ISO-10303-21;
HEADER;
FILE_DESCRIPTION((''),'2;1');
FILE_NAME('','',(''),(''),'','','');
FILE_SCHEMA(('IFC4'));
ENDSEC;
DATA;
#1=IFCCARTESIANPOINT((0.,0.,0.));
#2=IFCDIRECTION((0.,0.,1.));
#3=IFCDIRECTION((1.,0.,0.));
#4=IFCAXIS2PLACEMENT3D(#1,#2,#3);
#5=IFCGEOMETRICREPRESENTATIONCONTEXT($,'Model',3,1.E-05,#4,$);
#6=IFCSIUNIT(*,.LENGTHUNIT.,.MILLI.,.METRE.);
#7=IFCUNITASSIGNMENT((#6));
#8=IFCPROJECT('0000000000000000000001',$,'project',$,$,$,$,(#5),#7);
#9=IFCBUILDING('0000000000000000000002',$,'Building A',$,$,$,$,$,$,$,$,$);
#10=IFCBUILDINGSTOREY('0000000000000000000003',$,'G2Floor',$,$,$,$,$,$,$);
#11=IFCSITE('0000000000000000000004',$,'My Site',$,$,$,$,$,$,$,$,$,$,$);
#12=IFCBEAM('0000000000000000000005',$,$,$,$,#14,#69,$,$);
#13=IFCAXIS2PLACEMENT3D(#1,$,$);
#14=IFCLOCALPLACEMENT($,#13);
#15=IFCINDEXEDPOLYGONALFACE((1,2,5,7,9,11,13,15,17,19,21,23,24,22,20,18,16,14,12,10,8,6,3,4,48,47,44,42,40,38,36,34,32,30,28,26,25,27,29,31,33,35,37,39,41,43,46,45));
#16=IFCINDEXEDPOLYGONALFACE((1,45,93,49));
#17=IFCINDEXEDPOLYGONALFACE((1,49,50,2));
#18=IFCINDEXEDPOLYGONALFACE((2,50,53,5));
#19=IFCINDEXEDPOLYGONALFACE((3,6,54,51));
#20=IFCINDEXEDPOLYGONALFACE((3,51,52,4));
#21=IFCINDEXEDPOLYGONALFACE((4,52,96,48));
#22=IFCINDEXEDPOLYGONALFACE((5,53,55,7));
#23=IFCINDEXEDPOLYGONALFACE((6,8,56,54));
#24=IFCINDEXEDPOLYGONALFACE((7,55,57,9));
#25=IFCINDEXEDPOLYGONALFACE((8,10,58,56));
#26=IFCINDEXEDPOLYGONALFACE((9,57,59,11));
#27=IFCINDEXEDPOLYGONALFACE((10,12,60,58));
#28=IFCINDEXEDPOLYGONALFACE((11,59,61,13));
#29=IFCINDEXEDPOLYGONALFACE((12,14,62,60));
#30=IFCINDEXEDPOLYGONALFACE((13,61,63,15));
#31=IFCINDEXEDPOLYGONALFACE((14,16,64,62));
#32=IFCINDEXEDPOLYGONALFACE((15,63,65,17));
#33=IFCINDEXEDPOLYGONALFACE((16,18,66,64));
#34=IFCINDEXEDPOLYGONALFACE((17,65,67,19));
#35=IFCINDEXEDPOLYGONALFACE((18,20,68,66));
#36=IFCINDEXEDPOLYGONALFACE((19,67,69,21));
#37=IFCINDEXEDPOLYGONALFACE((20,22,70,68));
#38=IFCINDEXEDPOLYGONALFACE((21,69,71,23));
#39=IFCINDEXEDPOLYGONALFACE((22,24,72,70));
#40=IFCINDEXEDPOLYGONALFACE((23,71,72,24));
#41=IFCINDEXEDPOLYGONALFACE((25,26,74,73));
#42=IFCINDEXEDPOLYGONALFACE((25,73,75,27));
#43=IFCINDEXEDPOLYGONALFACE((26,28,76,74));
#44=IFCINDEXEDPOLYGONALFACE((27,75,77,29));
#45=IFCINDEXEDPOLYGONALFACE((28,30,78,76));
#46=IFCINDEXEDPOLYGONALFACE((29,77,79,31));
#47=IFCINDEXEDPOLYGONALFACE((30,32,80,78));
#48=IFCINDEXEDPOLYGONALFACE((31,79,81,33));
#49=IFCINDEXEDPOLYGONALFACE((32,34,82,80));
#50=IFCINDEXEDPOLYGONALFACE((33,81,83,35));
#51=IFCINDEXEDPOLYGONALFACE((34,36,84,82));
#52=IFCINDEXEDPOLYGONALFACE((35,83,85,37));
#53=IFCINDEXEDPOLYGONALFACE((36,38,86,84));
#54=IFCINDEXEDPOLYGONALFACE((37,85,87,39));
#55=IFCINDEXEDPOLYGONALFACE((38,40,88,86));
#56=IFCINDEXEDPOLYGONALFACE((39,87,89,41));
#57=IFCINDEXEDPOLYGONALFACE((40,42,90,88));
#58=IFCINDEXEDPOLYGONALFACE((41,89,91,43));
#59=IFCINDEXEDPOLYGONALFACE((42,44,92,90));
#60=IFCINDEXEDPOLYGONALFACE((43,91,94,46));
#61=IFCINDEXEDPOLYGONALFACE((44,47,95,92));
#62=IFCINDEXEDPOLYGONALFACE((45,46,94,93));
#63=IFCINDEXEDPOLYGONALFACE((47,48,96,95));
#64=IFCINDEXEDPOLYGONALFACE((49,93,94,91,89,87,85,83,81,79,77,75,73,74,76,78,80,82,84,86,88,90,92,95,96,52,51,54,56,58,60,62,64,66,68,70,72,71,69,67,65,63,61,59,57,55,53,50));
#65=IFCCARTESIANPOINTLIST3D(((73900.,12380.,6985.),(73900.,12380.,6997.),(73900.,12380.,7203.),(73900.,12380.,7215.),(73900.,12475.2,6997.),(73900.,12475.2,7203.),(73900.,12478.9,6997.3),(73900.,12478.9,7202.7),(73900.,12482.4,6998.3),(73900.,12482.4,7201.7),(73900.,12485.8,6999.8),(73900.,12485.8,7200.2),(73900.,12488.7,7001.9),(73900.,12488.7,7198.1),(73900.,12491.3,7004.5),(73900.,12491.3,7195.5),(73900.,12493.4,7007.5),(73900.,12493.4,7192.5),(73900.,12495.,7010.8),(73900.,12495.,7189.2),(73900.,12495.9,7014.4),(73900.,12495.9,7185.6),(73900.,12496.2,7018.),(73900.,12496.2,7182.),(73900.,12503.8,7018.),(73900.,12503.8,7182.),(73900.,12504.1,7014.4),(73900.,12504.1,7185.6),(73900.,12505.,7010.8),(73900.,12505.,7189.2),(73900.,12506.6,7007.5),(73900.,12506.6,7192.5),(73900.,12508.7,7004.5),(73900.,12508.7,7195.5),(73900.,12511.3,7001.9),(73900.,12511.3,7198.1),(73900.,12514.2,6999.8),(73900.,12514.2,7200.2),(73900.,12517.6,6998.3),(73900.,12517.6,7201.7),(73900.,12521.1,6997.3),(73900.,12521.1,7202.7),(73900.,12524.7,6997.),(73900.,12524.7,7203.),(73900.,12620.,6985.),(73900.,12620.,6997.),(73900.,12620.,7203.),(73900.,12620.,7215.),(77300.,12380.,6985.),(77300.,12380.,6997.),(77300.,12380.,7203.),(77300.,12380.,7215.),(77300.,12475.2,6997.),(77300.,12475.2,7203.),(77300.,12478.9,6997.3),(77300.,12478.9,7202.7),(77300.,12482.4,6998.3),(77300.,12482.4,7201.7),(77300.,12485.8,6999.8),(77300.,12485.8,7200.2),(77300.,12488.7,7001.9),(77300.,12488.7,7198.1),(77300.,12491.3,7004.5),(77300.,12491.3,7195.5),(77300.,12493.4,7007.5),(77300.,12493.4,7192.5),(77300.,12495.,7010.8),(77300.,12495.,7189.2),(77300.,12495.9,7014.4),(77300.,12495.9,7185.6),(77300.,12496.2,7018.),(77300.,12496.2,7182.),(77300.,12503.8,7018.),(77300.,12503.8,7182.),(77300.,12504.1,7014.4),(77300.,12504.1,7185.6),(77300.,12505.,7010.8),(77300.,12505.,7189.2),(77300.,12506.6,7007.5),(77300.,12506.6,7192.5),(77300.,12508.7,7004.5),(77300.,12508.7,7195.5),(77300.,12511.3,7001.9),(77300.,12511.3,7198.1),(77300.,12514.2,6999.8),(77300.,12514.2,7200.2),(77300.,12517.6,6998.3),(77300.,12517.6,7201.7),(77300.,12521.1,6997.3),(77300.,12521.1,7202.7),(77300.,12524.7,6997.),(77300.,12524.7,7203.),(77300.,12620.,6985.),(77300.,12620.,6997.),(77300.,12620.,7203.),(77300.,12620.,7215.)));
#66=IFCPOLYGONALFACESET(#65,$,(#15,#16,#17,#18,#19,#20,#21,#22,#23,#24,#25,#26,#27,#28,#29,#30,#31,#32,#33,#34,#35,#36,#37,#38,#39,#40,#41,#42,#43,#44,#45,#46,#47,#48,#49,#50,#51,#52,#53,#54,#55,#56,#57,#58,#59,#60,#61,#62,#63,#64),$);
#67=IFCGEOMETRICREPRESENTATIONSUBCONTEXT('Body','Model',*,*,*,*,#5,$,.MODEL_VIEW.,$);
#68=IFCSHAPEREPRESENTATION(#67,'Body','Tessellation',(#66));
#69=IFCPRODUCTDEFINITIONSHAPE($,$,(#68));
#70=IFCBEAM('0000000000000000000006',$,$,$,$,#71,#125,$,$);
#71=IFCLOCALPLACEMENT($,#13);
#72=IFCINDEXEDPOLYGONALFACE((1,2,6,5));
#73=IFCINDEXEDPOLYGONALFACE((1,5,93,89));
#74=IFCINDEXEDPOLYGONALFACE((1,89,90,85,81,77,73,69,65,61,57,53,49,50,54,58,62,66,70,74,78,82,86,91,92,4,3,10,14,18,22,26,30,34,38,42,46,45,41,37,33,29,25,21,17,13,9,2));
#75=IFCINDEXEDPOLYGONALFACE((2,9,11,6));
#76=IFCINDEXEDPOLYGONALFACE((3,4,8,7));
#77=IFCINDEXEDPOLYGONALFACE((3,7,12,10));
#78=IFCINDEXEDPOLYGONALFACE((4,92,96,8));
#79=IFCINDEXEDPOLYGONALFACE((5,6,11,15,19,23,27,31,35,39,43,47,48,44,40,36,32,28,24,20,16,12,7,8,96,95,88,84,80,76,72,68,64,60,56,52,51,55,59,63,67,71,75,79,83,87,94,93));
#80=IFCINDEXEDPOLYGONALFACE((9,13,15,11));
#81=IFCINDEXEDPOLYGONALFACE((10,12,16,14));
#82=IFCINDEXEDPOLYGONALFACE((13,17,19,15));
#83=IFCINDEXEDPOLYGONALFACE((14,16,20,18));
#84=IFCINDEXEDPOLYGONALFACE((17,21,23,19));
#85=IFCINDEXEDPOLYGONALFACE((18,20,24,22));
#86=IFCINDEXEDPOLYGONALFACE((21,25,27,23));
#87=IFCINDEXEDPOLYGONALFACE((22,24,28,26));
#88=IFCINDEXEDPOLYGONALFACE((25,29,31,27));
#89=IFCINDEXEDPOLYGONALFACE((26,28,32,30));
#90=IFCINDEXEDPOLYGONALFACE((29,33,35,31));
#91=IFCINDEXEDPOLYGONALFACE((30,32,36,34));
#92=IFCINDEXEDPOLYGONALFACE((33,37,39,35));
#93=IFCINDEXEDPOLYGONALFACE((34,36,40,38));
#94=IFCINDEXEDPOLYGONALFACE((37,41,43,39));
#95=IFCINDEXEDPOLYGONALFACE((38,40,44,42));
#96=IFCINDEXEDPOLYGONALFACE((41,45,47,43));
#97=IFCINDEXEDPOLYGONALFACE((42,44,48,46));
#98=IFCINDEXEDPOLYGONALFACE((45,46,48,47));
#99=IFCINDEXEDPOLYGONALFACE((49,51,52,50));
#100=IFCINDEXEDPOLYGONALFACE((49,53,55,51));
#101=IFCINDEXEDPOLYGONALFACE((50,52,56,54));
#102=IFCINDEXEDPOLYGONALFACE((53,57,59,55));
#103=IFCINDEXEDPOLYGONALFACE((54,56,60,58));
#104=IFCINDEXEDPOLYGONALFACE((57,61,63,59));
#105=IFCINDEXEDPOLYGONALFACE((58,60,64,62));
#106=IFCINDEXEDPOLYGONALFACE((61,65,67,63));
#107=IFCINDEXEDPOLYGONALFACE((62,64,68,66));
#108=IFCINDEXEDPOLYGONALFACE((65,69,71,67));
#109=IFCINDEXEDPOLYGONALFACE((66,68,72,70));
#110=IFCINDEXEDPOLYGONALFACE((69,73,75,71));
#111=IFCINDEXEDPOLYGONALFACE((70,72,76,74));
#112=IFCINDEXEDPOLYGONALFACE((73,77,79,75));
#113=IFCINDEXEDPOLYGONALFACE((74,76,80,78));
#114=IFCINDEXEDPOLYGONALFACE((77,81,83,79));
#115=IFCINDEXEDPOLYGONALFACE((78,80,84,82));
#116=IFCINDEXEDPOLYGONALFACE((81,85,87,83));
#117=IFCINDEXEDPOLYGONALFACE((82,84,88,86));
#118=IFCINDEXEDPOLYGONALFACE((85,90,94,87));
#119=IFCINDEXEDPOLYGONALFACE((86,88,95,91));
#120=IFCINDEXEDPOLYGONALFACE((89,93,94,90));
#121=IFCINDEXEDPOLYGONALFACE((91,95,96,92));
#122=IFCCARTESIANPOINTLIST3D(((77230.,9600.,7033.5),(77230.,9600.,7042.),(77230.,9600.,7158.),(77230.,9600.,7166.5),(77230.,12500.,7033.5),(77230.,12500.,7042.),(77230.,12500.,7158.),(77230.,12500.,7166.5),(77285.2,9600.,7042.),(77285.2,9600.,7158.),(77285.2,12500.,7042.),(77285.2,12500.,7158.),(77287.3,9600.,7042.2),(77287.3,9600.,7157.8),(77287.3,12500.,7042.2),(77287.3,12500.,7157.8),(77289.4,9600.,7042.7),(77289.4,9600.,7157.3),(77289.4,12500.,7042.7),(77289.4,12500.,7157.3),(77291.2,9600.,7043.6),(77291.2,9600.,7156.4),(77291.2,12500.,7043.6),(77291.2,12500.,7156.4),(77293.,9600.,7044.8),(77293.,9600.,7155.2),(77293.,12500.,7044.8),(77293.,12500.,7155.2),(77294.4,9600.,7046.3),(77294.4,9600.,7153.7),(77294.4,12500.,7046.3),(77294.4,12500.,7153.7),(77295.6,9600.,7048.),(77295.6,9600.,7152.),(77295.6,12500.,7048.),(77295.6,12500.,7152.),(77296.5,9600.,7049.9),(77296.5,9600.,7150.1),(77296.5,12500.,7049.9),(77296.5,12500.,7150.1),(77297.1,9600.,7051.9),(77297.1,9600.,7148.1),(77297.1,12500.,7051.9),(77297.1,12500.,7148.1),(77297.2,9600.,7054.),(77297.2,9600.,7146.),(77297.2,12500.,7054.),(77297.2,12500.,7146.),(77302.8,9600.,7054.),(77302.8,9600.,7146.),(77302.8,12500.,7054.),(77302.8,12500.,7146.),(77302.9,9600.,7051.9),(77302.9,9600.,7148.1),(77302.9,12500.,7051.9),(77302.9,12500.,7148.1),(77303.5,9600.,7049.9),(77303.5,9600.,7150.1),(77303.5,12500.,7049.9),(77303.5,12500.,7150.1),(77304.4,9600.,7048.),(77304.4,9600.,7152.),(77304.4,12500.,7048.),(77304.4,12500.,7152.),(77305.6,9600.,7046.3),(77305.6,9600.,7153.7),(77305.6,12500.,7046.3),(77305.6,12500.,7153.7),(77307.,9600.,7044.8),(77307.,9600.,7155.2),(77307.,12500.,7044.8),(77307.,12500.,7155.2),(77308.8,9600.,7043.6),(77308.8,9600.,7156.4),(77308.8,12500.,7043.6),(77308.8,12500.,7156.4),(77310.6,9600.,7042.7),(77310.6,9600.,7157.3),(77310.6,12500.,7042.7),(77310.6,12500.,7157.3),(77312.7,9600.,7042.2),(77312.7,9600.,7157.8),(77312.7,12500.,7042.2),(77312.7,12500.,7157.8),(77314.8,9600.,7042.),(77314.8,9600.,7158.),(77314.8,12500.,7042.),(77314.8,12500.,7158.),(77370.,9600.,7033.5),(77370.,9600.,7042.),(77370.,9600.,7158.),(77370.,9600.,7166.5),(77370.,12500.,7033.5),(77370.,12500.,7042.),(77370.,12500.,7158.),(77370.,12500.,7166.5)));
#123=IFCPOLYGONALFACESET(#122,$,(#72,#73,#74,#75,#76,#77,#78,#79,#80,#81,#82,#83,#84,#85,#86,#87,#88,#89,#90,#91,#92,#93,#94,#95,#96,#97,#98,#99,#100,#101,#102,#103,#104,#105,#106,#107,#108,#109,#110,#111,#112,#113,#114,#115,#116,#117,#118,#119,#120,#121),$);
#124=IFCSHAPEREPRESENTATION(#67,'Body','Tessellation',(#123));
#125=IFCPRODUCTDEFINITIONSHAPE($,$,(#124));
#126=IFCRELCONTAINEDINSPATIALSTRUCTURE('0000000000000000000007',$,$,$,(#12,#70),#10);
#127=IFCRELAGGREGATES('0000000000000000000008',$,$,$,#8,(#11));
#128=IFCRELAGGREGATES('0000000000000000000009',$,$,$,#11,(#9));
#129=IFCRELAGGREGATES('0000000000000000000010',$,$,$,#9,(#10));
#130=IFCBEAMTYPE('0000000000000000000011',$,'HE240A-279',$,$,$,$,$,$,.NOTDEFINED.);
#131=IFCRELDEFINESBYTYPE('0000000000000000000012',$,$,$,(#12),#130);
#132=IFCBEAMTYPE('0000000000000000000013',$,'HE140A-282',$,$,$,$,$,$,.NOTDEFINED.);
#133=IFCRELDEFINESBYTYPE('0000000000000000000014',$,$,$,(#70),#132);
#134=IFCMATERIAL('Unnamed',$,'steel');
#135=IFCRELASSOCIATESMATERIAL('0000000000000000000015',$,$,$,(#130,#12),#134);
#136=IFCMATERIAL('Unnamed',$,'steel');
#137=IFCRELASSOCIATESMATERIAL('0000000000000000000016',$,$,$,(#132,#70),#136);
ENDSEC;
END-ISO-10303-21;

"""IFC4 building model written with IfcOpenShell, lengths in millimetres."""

from ifc_helpers import new_model, si_unit, frame, origin_with_axes, place, context, subcontext, project, spatial, polyline, outline, extrude, material, material_profile, profile_set, profile_usage, type_object, element, save


model = new_model("IFC4")

# Units and contexts
model_context = context("Model", 3, precision=1e-05, world=origin_with_axes())
body_context = subcontext(model_context, "Body", "Model", "MODEL_VIEW")
ifc_project = project(units=[si_unit("LENGTHUNIT", "METRE", prefix="MILLI")], contexts=[model_context])

# Site, building, storey
site = spatial("IfcSite", under=ifc_project, Name="My Site")
building = spatial("IfcBuilding", under=site, Name="Building A")
storey = spatial("IfcBuildingStorey", under=building, Name="G2Floor")

# Beams
ifc_material_1 = material(Name="Unnamed", Category="steel")
ifc_material_profile_1 = material_profile(ifc_material_1, outline(polyline([(120.0, -115.0), (120.0, -103.0), (120.0, -103.0), (24.8, -103.0), (24.8, -103.0), (21.1, -102.7), (21.1, -102.7), (17.6, -101.7), (17.6, -101.7), (14.2, -100.2), (14.2, -100.2), (11.3, -98.1), (11.3, -98.1), (8.7, -95.5), (8.7, -95.5), (6.6, -92.5), (6.6, -92.5), (5.0, -89.2), (5.0, -89.2), (4.1, -85.6), (4.1, -85.6), (3.8, -82.0), (3.8, -82.0), (3.8, 82.0), (3.8, 82.0), (4.1, 85.6), (4.1, 85.6), (5.0, 89.2), (5.0, 89.2), (6.6, 92.5), (6.6, 92.5), (8.7, 95.5), (8.7, 95.5), (11.3, 98.1), (11.3, 98.1), (14.2, 100.2), (14.2, 100.2), (17.6, 101.7), (17.6, 101.7), (21.1, 102.7), (21.1, 102.7), (24.8, 103.0), (24.8, 103.0), (120.0, 103.0), (120.0, 103.0), (120.0, 115.0), (120.0, 115.0), (-120.0, 115.0), (-120.0, 115.0), (-120.0, 103.0), (-120.0, 103.0), (-24.8, 103.0), (-24.8, 103.0), (-21.1, 102.7), (-21.1, 102.7), (-17.6, 101.7), (-17.6, 101.7), (-14.2, 100.2), (-14.2, 100.2), (-11.3, 98.1), (-11.3, 98.1), (-8.7, 95.5), (-8.7, 95.5), (-6.6, 92.5), (-6.6, 92.5), (-5.0, 89.2), (-5.0, 89.2), (-4.1, 85.6), (-4.1, 85.6), (-3.8, 82.0), (-3.8, 82.0), (-3.8, -82.0), (-3.8, -82.0), (-4.1, -85.6), (-4.1, -85.6), (-5.0, -89.2), (-5.0, -89.2), (-6.6, -92.5), (-6.6, -92.5), (-8.7, -95.5), (-8.7, -95.5), (-11.3, -98.1), (-11.3, -98.1), (-14.2, -100.2), (-14.2, -100.2), (-17.6, -101.7), (-17.6, -101.7), (-21.1, -102.7), (-21.1, -102.7), (-24.8, -103.0), (-24.8, -103.0), (-120.0, -103.0), (-120.0, -103.0), (-120.0, -115.0), (-120.0, -115.0), (120.0, -115.0)])))
ifc_profile_set_1 = profile_set([ifc_material_profile_1], Name="HE240A-279")
ifc_profile_usage_1 = profile_usage(ifc_profile_set_1)
beam_type_1 = type_object("IfcBeamType", Name="HE240A-279", PredefinedType="NOTDEFINED", material=ifc_profile_set_1)
beam_1_placement = place(None, frame((73900.0, 12500.0, 7100.0), z_axis=(1.0, 0.0, 0.0), x_axis=(0.0, -1.0, 0.0)))
element("IfcBeam", 1, at=beam_1_placement, inside=storey, type_object=beam_type_1, material=ifc_profile_usage_1, context=body_context, shape_type="SweptSolid", body=[
    extrude(outline(polyline([(120.0, -115.0), (120.0, -103.0), (120.0, -103.0), (24.8, -103.0), (24.8, -103.0), (21.1, -102.7), (21.1, -102.7), (17.6, -101.7), (17.6, -101.7), (14.2, -100.2), (14.2, -100.2), (11.3, -98.1), (11.3, -98.1), (8.7, -95.5), (8.7, -95.5), (6.6, -92.5), (6.6, -92.5), (5.0, -89.2), (5.0, -89.2), (4.1, -85.6), (4.1, -85.6), (3.8, -82.0), (3.8, -82.0), (3.8, 82.0), (3.8, 82.0), (4.1, 85.6), (4.1, 85.6), (5.0, 89.2), (5.0, 89.2), (6.6, 92.5), (6.6, 92.5), (8.7, 95.5), (8.7, 95.5), (11.3, 98.1), (11.3, 98.1), (14.2, 100.2), (14.2, 100.2), (17.6, 101.7), (17.6, 101.7), (21.1, 102.7), (21.1, 102.7), (24.8, 103.0), (24.8, 103.0), (120.0, 103.0), (120.0, 103.0), (120.0, 115.0), (120.0, 115.0), (-120.0, 115.0), (-120.0, 115.0), (-120.0, 103.0), (-120.0, 103.0), (-24.8, 103.0), (-24.8, 103.0), (-21.1, 102.7), (-21.1, 102.7), (-17.6, 101.7), (-17.6, 101.7), (-14.2, 100.2), (-14.2, 100.2), (-11.3, 98.1), (-11.3, 98.1), (-8.7, 95.5), (-8.7, 95.5), (-6.6, 92.5), (-6.6, 92.5), (-5.0, 89.2), (-5.0, 89.2), (-4.1, 85.6), (-4.1, 85.6), (-3.8, 82.0), (-3.8, 82.0), (-3.8, -82.0), (-3.8, -82.0), (-4.1, -85.6), (-4.1, -85.6), (-5.0, -89.2), (-5.0, -89.2), (-6.6, -92.5), (-6.6, -92.5), (-8.7, -95.5), (-8.7, -95.5), (-11.3, -98.1), (-11.3, -98.1), (-14.2, -100.2), (-14.2, -100.2), (-17.6, -101.7), (-17.6, -101.7), (-21.1, -102.7), (-21.1, -102.7), (-24.8, -103.0), (-24.8, -103.0), (-120.0, -103.0), (-120.0, -103.0), (-120.0, -115.0), (-120.0, -115.0), (120.0, -115.0)])), origin_with_axes(), (0.0, 0.0, 1.0), 3400.0),
])
ifc_material_2 = material(Name="Unnamed", Category="steel")
ifc_material_profile_2 = material_profile(ifc_material_2, outline(polyline([(70.0, -66.5), (70.0, -58.0), (70.0, -58.0), (14.8, -58.0), (14.8, -58.0), (12.7, -57.8), (12.7, -57.8), (10.6, -57.3), (10.6, -57.3), (8.8, -56.4), (8.8, -56.4), (7.0, -55.2), (7.0, -55.2), (5.6, -53.7), (5.6, -53.7), (4.4, -52.0), (4.4, -52.0), (3.5, -50.1), (3.5, -50.1), (2.9, -48.1), (2.9, -48.1), (2.8, -46.0), (2.8, -46.0), (2.8, 46.0), (2.8, 46.0), (2.9, 48.1), (2.9, 48.1), (3.5, 50.1), (3.5, 50.1), (4.4, 52.0), (4.4, 52.0), (5.6, 53.7), (5.6, 53.7), (7.0, 55.2), (7.0, 55.2), (8.8, 56.4), (8.8, 56.4), (10.6, 57.3), (10.6, 57.3), (12.7, 57.8), (12.7, 57.8), (14.8, 58.0), (14.8, 58.0), (70.0, 58.0), (70.0, 58.0), (70.0, 66.5), (70.0, 66.5), (-70.0, 66.5), (-70.0, 66.5), (-70.0, 58.0), (-70.0, 58.0), (-14.8, 58.0), (-14.8, 58.0), (-12.7, 57.8), (-12.7, 57.8), (-10.6, 57.3), (-10.6, 57.3), (-8.8, 56.4), (-8.8, 56.4), (-7.0, 55.2), (-7.0, 55.2), (-5.6, 53.7), (-5.6, 53.7), (-4.4, 52.0), (-4.4, 52.0), (-3.5, 50.1), (-3.5, 50.1), (-2.9, 48.1), (-2.9, 48.1), (-2.8, 46.0), (-2.8, 46.0), (-2.8, -46.0), (-2.8, -46.0), (-2.9, -48.1), (-2.9, -48.1), (-3.5, -50.1), (-3.5, -50.1), (-4.4, -52.0), (-4.4, -52.0), (-5.6, -53.7), (-5.6, -53.7), (-7.0, -55.2), (-7.0, -55.2), (-8.8, -56.4), (-8.8, -56.4), (-10.6, -57.3), (-10.6, -57.3), (-12.7, -57.8), (-12.7, -57.8), (-14.8, -58.0), (-14.8, -58.0), (-70.0, -58.0), (-70.0, -58.0), (-70.0, -66.5), (-70.0, -66.5), (70.0, -66.5)])))
ifc_profile_set_2 = profile_set([ifc_material_profile_2], Name="HE140A-282")
ifc_profile_usage_2 = profile_usage(ifc_profile_set_2)
beam_type_2 = type_object("IfcBeamType", Name="HE140A-282", PredefinedType="NOTDEFINED", material=ifc_profile_set_2)
beam_2_placement = place(None, frame((77300.0, 9600.0, 7100.0), z_axis=(0.0, 1.0, 0.0), x_axis=(1.0, 0.0, 0.0)))
element("IfcBeam", 2, at=beam_2_placement, inside=storey, type_object=beam_type_2, material=ifc_profile_usage_2, context=body_context, shape_type="SweptSolid", body=[
    extrude(outline(polyline([(70.0, -66.5), (70.0, -58.0), (70.0, -58.0), (14.8, -58.0), (14.8, -58.0), (12.7, -57.8), (12.7, -57.8), (10.6, -57.3), (10.6, -57.3), (8.8, -56.4), (8.8, -56.4), (7.0, -55.2), (7.0, -55.2), (5.6, -53.7), (5.6, -53.7), (4.4, -52.0), (4.4, -52.0), (3.5, -50.1), (3.5, -50.1), (2.9, -48.1), (2.9, -48.1), (2.8, -46.0), (2.8, -46.0), (2.8, 46.0), (2.8, 46.0), (2.9, 48.1), (2.9, 48.1), (3.5, 50.1), (3.5, 50.1), (4.4, 52.0), (4.4, 52.0), (5.6, 53.7), (5.6, 53.7), (7.0, 55.2), (7.0, 55.2), (8.8, 56.4), (8.8, 56.4), (10.6, 57.3), (10.6, 57.3), (12.7, 57.8), (12.7, 57.8), (14.8, 58.0), (14.8, 58.0), (70.0, 58.0), (70.0, 58.0), (70.0, 66.5), (70.0, 66.5), (-70.0, 66.5), (-70.0, 66.5), (-70.0, 58.0), (-70.0, 58.0), (-14.8, 58.0), (-14.8, 58.0), (-12.7, 57.8), (-12.7, 57.8), (-10.6, 57.3), (-10.6, 57.3), (-8.8, 56.4), (-8.8, 56.4), (-7.0, 55.2), (-7.0, 55.2), (-5.6, 53.7), (-5.6, 53.7), (-4.4, 52.0), (-4.4, 52.0), (-3.5, 50.1), (-3.5, 50.1), (-2.9, 48.1), (-2.9, 48.1), (-2.8, 46.0), (-2.8, 46.0), (-2.8, -46.0), (-2.8, -46.0), (-2.9, -48.1), (-2.9, -48.1), (-3.5, -50.1), (-3.5, -50.1), (-4.4, -52.0), (-4.4, -52.0), (-5.6, -53.7), (-5.6, -53.7), (-7.0, -55.2), (-7.0, -55.2), (-8.8, -56.4), (-8.8, -56.4), (-10.6, -57.3), (-10.6, -57.3), (-12.7, -57.8), (-12.7, -57.8), (-14.8, -58.0), (-14.8, -58.0), (-70.0, -58.0), (-70.0, -58.0), (-70.0, -66.5), (-70.0, -66.5), (70.0, -66.5)])), origin_with_axes(), (0.0, 0.0, 1.0), 2900.0),
])

save(model, "model.ifc")
